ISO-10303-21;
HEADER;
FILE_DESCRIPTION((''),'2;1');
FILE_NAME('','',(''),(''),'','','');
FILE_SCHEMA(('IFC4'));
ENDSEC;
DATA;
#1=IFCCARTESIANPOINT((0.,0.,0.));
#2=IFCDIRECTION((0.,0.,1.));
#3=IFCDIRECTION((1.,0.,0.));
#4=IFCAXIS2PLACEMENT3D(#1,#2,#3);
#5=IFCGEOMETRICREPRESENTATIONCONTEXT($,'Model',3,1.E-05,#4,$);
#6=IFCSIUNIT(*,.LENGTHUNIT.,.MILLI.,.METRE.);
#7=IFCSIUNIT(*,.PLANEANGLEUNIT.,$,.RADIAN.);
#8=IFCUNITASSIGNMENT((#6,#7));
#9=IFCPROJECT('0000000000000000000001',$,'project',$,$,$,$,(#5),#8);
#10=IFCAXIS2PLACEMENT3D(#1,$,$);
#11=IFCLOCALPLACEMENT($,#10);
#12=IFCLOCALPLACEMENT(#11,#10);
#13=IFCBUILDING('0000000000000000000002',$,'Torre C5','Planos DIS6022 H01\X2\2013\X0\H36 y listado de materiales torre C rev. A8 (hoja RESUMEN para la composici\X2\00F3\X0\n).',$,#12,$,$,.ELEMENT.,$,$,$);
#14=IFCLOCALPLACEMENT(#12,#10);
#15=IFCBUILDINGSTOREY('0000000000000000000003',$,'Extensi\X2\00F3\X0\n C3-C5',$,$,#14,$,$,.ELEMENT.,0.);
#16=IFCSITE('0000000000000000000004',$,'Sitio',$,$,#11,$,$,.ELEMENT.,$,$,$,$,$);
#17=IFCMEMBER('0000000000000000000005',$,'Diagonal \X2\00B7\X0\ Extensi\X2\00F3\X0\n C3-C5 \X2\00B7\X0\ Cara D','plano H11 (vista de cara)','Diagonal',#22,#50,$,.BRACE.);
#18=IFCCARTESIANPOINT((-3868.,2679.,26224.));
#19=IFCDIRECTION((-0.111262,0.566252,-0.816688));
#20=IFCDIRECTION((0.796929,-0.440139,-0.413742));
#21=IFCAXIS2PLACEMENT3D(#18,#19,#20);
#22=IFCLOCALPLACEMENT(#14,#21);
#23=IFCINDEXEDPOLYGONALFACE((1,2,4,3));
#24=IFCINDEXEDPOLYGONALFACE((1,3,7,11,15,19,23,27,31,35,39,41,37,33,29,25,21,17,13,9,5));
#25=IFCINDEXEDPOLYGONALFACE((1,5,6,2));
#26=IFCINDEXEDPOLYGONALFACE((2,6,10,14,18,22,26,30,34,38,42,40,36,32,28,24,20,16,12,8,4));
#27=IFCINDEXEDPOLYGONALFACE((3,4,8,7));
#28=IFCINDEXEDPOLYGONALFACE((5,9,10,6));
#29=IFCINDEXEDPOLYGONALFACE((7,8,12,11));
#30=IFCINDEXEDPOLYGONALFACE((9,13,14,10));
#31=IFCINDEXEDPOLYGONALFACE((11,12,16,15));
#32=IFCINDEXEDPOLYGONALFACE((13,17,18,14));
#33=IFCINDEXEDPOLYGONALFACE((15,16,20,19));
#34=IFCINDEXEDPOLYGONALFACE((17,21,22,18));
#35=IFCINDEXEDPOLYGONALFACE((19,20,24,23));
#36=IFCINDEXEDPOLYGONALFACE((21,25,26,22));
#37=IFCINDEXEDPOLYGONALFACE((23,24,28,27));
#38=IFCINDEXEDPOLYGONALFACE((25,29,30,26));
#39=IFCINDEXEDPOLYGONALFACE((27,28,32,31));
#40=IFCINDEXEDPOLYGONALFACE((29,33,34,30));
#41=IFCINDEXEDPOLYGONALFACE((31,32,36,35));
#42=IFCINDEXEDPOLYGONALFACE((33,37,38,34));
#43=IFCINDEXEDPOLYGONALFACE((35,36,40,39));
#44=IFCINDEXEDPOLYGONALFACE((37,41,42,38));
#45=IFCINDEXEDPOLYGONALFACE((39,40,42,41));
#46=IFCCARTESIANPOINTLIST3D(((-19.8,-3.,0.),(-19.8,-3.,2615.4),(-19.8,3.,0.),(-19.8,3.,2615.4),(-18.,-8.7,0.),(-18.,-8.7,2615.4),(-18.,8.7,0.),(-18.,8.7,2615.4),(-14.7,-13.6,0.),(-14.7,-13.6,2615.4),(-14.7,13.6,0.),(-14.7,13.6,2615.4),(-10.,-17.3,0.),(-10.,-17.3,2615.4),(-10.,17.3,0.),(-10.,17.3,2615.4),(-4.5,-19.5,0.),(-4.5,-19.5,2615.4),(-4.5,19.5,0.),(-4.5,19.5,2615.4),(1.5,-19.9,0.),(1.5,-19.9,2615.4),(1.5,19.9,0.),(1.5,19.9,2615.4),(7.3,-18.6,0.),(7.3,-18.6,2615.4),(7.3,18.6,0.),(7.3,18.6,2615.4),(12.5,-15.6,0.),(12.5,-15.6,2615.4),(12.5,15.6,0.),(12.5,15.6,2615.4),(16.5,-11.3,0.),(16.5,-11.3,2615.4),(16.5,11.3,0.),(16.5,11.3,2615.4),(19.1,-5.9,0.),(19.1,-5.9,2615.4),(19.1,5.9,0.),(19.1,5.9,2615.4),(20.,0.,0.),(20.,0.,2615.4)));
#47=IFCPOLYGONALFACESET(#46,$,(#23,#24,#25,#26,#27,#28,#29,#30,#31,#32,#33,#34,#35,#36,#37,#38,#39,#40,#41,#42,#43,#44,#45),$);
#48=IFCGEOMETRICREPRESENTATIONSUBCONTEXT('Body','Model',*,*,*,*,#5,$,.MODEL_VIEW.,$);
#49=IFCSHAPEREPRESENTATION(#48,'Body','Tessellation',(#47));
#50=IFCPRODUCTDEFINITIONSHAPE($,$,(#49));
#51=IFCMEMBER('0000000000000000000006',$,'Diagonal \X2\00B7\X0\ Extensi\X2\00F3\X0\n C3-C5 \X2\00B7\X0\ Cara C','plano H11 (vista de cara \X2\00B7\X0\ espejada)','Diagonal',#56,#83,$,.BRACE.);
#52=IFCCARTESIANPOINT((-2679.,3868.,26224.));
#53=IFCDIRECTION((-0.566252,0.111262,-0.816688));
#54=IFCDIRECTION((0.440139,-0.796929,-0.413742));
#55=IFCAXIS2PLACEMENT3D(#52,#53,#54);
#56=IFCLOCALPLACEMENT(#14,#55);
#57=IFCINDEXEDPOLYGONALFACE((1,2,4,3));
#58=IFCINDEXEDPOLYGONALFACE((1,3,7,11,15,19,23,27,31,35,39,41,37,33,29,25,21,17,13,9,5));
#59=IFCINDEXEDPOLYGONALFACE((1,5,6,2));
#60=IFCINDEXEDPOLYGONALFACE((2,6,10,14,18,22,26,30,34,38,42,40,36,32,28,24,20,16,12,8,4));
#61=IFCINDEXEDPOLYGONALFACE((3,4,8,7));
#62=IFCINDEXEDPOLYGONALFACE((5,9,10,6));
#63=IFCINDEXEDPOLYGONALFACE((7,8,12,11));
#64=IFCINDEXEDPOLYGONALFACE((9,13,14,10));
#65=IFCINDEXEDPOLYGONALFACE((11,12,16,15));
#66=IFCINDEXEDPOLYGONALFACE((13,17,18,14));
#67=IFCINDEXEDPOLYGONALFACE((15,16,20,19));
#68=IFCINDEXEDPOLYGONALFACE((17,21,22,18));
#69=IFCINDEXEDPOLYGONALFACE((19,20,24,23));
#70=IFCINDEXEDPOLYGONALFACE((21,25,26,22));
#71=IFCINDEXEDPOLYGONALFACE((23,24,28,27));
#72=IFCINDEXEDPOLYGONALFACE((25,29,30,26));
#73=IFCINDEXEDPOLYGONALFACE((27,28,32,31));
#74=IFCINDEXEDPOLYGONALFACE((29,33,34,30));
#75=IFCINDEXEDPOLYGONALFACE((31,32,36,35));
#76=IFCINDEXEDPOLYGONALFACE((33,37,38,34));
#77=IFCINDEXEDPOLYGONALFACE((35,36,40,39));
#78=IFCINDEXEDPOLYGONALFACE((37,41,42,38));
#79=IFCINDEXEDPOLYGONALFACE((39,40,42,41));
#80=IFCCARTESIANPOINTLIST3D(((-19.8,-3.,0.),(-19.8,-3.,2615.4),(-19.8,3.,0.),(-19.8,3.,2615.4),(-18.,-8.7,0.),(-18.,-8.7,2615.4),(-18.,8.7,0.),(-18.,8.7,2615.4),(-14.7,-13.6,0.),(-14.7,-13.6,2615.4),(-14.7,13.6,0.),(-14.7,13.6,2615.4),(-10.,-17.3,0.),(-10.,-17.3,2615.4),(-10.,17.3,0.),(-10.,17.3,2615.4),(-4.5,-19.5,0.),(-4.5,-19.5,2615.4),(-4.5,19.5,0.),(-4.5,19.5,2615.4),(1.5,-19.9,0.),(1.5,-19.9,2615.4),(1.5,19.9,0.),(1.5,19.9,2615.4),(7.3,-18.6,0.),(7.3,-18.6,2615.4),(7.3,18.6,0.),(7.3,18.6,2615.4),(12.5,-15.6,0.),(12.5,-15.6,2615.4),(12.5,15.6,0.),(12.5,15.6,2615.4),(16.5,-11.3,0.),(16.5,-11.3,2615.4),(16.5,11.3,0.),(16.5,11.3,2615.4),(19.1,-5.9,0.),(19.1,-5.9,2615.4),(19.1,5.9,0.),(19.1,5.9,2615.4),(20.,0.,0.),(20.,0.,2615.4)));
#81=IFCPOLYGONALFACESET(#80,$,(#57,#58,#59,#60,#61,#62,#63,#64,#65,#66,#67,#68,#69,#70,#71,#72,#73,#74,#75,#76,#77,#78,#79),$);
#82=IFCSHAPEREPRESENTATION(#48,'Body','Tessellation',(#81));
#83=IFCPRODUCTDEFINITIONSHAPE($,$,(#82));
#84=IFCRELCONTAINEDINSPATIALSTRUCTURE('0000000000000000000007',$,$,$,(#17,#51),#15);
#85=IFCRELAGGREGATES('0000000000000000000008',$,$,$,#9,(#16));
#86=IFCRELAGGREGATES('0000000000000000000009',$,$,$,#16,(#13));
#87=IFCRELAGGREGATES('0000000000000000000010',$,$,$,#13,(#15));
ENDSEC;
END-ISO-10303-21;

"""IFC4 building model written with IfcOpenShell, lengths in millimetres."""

from ifc_helpers import new_model, si_unit, frame, origin, origin_with_axes, place, context, subcontext, project, spatial, circle, extrude, element, save


model = new_model("IFC4")

# Units and contexts
model_context = context("Model", 3, precision=1e-05, world=origin_with_axes())
body_context = subcontext(model_context, "Body", "Model", "MODEL_VIEW")
ifc_project = project(units=[si_unit("LENGTHUNIT", "METRE", prefix="MILLI"), si_unit("PLANEANGLEUNIT", "RADIAN")], contexts=[model_context])

# Site, building, storey
site_placement = place(None, origin())
site = spatial("IfcSite", under=ifc_project, at=site_placement, Name="Sitio", CompositionType="ELEMENT")
building_placement = place(site_placement, origin())
building = spatial("IfcBuilding", under=site, at=building_placement, Name="Torre C5", Description="Planos DIS6022 H01–H36 y listado de materiales torre C rev. A8 (hoja RESUMEN para la composición).", CompositionType="ELEMENT")
storey_placement = place(building_placement, origin())
storey = spatial("IfcBuildingStorey", under=building, at=storey_placement, Name="Extensión C3-C5", CompositionType="ELEMENT", Elevation=0.0)

# Members
for number, where, z_axis, x_axis, name, description in (
    (1, (-3868.0, 2679.0, 26224.0), (-0.111262, 0.566252, -0.816688), (0.796929, -0.440139, -0.413742), "Diagonal · Extensión C3-C5 · Cara D", "plano H11 (vista de cara)"),
    (2, (-2679.0, 3868.0, 26224.0), (-0.566252, 0.111262, -0.816688), (0.440139, -0.796929, -0.413742), "Diagonal · Extensión C3-C5 · Cara C", "plano H11 (vista de cara · espejada)"),
):
    element("IfcMember", number, at=place(storey_placement, frame(where, z_axis=z_axis, x_axis=x_axis)), inside=storey, Name=name, Description=description, ObjectType="Diagonal", PredefinedType="BRACE", context=body_context, shape_type="SweptSolid", body=[
        extrude(circle(Radius=20.0), None, (0.0, 0.0, 1.0), 2615.4),
    ])

save(model, "model.ifc")
